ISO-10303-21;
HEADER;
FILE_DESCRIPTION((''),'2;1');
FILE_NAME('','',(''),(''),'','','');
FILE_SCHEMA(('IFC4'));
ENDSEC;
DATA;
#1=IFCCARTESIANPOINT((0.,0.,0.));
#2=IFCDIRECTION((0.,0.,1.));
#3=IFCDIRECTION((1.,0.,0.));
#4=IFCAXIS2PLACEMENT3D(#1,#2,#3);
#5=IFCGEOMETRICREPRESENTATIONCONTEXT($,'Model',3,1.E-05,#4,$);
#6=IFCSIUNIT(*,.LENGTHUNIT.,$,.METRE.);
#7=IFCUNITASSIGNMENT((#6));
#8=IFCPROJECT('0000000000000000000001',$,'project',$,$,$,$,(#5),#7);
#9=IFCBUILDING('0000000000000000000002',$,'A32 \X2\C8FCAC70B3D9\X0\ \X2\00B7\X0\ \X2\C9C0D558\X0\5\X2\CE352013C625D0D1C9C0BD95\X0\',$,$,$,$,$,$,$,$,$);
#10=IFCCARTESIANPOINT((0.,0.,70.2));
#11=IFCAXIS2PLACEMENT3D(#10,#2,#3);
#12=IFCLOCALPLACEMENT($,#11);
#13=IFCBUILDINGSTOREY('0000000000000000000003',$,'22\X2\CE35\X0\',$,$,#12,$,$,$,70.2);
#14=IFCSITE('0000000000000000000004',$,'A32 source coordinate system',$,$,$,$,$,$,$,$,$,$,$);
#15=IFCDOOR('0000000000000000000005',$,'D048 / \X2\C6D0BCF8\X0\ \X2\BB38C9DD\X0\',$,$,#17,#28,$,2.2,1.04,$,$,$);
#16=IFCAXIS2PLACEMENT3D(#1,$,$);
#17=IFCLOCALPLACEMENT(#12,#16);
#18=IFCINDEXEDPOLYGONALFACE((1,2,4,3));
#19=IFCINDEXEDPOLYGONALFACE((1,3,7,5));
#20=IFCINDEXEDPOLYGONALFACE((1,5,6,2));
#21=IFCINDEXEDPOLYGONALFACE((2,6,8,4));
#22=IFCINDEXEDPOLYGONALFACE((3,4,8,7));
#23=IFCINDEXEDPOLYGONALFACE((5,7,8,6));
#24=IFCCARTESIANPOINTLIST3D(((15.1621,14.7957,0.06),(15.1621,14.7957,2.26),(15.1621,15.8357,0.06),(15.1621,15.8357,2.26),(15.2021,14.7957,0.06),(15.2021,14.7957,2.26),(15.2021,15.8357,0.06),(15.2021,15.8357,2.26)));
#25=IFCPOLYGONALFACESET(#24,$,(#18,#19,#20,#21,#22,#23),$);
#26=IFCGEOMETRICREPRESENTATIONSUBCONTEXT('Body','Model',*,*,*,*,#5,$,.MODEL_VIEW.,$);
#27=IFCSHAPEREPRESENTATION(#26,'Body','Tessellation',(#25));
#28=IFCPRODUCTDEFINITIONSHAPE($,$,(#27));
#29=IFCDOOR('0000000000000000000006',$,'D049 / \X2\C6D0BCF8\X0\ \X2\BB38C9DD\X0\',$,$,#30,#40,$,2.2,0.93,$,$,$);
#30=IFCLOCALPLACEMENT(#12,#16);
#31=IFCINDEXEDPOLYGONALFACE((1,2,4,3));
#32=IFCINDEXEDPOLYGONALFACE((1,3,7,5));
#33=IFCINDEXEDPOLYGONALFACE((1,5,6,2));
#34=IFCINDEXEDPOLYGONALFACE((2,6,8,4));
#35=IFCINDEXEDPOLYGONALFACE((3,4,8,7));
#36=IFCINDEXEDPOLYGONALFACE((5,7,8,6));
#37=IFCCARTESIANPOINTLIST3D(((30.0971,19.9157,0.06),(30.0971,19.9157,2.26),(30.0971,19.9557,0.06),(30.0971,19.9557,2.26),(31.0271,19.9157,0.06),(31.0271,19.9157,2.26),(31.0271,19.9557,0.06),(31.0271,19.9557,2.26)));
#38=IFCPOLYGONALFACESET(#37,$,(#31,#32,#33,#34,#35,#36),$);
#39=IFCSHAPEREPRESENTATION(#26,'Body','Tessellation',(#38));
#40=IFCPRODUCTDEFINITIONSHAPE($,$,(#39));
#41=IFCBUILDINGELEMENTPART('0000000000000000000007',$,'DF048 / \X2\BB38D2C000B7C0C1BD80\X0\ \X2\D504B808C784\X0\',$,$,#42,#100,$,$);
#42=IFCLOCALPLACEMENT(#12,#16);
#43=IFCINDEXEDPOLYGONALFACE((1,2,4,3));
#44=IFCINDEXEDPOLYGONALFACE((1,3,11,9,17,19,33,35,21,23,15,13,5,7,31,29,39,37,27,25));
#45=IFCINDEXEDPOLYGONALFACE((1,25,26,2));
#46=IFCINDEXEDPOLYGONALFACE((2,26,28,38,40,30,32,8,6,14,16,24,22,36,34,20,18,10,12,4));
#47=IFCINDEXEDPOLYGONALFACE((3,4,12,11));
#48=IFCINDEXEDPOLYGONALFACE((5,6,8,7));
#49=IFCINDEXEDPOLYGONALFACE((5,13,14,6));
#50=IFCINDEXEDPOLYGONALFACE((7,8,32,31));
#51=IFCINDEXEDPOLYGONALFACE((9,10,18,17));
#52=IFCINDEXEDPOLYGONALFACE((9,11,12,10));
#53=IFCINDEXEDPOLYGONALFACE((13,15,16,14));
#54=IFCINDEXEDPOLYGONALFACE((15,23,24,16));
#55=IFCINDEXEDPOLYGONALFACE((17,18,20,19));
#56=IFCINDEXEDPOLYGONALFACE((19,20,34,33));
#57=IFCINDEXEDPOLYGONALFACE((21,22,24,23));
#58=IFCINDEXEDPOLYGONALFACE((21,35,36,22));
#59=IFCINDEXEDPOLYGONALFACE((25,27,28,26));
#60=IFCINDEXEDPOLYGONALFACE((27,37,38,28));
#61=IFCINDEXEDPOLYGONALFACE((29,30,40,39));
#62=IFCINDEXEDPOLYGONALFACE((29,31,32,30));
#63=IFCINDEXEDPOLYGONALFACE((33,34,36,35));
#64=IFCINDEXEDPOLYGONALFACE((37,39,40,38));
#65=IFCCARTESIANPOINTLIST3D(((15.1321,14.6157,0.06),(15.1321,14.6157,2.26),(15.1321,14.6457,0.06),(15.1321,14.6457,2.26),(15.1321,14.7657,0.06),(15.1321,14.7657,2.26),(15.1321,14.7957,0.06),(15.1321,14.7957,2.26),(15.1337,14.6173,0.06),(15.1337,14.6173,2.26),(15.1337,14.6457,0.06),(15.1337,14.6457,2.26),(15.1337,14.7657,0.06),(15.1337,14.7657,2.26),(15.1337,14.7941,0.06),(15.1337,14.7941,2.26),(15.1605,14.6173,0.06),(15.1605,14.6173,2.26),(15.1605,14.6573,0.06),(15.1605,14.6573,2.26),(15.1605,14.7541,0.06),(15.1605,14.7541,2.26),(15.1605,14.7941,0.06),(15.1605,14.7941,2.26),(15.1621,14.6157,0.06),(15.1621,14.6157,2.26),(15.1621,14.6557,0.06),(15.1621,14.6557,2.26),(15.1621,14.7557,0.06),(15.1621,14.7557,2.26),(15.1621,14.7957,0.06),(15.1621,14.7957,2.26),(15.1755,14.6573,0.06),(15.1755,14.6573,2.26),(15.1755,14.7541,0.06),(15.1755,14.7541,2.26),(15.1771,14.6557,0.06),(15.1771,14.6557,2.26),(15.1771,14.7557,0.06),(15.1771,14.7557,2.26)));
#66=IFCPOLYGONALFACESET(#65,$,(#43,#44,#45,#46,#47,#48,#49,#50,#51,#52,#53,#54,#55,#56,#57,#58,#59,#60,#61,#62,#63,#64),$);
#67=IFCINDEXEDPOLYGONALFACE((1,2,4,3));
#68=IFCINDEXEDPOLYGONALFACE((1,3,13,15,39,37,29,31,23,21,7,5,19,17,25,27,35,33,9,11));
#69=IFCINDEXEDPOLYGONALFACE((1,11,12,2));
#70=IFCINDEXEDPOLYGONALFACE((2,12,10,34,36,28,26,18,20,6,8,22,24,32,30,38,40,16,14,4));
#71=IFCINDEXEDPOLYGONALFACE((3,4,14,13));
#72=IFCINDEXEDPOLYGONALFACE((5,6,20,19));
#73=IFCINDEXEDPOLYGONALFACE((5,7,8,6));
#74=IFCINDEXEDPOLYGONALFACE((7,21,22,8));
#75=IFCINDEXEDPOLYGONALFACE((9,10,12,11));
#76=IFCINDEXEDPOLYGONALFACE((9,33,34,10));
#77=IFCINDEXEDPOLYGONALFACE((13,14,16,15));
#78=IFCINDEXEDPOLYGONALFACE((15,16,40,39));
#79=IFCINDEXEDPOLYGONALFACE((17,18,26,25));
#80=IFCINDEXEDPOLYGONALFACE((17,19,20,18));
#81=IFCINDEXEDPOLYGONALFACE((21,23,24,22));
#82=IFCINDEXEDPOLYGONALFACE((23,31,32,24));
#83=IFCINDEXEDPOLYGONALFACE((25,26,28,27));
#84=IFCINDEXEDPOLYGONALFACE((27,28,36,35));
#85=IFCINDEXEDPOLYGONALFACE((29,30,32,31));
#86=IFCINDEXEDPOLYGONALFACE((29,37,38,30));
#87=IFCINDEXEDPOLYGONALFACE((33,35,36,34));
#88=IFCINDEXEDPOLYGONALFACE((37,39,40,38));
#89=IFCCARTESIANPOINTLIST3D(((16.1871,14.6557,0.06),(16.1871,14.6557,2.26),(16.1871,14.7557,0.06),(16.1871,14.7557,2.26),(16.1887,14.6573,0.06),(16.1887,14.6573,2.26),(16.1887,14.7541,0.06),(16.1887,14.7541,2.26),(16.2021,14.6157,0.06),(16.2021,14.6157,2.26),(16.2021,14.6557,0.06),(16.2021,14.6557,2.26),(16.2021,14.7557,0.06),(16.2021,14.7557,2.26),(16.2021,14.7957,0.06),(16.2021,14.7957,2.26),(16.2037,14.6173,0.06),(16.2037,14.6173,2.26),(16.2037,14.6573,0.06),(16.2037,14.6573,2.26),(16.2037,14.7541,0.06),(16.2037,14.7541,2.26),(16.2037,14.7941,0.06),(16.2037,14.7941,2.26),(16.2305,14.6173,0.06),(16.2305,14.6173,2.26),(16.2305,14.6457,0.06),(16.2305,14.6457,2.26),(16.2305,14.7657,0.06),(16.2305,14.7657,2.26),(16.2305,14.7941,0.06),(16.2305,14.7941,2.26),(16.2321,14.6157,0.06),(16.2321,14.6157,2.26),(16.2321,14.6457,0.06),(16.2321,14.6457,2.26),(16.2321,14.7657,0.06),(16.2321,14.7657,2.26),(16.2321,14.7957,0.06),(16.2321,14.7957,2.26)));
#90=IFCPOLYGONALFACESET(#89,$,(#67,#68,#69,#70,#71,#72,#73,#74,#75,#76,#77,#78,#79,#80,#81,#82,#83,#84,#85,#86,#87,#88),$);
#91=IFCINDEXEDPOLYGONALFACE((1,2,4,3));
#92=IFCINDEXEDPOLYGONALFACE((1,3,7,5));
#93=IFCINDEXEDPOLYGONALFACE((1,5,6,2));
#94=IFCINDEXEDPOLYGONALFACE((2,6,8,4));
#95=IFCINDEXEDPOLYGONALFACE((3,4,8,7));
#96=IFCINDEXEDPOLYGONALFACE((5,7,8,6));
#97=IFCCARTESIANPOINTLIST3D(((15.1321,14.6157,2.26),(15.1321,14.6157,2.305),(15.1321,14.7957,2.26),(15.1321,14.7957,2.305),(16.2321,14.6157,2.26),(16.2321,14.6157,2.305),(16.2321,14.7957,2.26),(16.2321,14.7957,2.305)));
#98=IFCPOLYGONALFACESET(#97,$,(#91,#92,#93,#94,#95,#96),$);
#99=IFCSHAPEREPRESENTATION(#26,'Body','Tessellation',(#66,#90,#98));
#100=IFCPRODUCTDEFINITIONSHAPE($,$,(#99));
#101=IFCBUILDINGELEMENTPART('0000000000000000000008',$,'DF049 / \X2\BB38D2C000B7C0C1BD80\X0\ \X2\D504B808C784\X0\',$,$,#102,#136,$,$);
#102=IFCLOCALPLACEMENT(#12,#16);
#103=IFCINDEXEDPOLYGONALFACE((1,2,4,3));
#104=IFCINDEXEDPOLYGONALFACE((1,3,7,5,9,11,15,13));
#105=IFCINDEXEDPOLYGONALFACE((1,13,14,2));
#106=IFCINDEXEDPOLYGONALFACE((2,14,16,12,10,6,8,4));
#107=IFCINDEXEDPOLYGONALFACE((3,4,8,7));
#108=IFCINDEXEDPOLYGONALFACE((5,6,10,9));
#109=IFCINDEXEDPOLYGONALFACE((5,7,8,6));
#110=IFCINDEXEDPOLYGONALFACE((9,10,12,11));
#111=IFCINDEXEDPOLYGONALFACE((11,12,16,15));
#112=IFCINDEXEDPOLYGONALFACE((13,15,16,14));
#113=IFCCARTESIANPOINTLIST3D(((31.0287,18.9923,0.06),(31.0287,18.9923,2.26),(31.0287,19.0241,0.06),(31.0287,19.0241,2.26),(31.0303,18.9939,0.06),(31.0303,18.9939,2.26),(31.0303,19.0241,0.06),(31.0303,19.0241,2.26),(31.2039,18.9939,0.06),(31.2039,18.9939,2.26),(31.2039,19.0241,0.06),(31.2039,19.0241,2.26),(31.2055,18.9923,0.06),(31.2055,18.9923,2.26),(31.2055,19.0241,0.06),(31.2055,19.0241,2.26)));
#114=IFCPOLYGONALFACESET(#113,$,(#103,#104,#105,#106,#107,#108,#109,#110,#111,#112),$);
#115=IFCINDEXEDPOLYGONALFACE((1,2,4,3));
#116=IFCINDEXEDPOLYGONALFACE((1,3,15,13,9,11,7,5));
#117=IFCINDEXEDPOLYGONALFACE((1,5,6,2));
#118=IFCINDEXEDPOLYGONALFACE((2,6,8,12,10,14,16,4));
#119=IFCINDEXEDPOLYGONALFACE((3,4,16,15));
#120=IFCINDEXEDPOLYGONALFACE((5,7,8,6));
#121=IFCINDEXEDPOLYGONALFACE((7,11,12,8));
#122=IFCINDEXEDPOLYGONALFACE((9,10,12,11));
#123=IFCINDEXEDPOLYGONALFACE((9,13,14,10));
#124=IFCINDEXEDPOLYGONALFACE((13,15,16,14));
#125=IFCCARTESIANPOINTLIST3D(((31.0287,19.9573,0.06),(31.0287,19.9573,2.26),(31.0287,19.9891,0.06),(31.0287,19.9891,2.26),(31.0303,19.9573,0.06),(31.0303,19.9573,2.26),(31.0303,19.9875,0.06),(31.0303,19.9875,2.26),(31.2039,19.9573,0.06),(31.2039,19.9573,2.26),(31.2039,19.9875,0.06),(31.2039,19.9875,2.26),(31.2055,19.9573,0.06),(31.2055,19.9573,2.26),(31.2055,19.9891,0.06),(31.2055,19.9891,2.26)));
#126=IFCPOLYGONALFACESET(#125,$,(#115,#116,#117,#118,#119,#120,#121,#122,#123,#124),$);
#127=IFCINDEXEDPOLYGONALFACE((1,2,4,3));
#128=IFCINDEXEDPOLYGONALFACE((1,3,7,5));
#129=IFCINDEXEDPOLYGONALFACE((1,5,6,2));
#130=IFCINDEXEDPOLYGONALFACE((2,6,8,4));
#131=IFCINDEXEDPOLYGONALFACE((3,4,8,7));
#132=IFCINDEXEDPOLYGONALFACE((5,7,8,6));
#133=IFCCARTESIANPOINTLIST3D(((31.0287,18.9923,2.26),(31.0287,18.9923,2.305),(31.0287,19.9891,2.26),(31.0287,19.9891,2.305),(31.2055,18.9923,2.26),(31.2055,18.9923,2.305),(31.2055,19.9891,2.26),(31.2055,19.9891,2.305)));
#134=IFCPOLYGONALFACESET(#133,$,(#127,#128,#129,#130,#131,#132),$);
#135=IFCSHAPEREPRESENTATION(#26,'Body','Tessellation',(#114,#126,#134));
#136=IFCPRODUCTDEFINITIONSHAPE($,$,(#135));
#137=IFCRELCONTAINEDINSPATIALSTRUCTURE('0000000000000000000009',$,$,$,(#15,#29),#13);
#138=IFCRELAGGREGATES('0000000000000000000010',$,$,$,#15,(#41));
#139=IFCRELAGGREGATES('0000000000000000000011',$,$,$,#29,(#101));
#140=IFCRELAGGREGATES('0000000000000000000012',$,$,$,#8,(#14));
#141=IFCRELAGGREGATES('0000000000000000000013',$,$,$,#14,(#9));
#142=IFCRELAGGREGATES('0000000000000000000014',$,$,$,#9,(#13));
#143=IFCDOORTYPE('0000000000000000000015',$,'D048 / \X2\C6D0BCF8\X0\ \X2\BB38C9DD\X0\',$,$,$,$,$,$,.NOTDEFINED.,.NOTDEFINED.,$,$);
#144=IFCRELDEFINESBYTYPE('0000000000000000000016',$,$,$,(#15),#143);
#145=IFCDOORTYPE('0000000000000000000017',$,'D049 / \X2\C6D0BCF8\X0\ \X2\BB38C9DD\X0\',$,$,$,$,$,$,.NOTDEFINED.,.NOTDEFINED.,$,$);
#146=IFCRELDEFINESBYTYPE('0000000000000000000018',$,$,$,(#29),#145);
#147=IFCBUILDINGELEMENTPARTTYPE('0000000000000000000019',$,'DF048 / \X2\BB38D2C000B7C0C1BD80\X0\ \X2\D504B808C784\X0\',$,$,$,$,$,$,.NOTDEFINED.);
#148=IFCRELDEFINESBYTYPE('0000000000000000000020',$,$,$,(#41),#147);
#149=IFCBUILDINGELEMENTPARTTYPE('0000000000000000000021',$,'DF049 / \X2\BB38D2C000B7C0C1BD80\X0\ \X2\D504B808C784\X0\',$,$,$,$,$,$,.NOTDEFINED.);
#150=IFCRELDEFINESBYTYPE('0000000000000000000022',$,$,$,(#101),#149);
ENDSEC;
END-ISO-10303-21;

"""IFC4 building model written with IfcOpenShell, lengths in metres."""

from ifc_helpers import new_model, si_unit, frame, origin, origin_with_axes, place, context, subcontext, project, spatial, polyline, outline, extrude, source, transform, mapped, type_object, type_shapes, element, aggregate, save


model = new_model("IFC4")

# Units and contexts
model_context = context("Model", 3, precision=1e-05, world=origin_with_axes())
body_context = subcontext(model_context, "Body", "Model", "MODEL_VIEW")
ifc_project = project(units=[si_unit("LENGTHUNIT", "METRE")], contexts=[model_context])

# Site, building, storey
storey_placement = place(None, frame((0.0, 0.0, 70.2), z_axis=(0.0, 0.0, 1.0), x_axis=(1.0, 0.0, 0.0)))
site = spatial("IfcSite", under=ifc_project, Name="A32 source coordinate system")
building = spatial("IfcBuilding", under=site, Name="A32 주거동 · 지하5층–옥탑지붕")
storey = spatial("IfcBuildingStorey", under=building, at=storey_placement, Name="22층", Elevation=70.2)

# Doors
door_type_1 = type_object("IfcDoorType", Name="D048 / 원본 문짝", OperationType="NOTDEFINED", PredefinedType="NOTDEFINED")
shared_shape_1 = source(origin(), body_context, "Body", "SweptSolid", [
    extrude(outline(polyline([(15.2021, 15.8357), (15.2021, 14.7957), (15.1621, 14.7957), (15.1621, 15.8357), (15.2021, 15.8357)])), frame((0.0, 0.0, 0.06)), (0.0, 0.0, 1.0), 2.2),
])
type_shapes(door_type_1, [shared_shape_1])
door_1_placement = place(storey_placement, origin_with_axes())
door_1 = element("IfcDoor", 1, at=door_1_placement, inside=storey, type_object=door_type_1, Name="D048 / 원본 문짝", OverallHeight=2.2, OverallWidth=1.04, context=body_context, shape_type="MappedRepresentation", body=[
    mapped(shared_shape_1, transform((0.0, 0.0, 0.0), scale=1.0)),
])
door_type_2 = type_object("IfcDoorType", Name="D049 / 원본 문짝", OperationType="NOTDEFINED", PredefinedType="NOTDEFINED")
shared_shape_2 = source(origin(), body_context, "Body", "SweptSolid", [
    extrude(outline(polyline([(31.0271, 19.9557), (31.0271, 19.9157), (30.0971, 19.9157), (30.0971, 19.9557), (31.0271, 19.9557)])), frame((0.0, 0.0, 0.06)), (0.0, 0.0, 1.0), 2.2),
])
type_shapes(door_type_2, [shared_shape_2])
door_2_placement = place(storey_placement, origin_with_axes())
door_2 = element("IfcDoor", 2, at=door_2_placement, inside=storey, type_object=door_type_2, Name="D049 / 원본 문짝", OverallHeight=2.2, OverallWidth=0.93, context=body_context, shape_type="MappedRepresentation", body=[
    mapped(shared_shape_2, transform((0.0, 0.0, 0.0), scale=1.0)),
])

# Building element parts
building_element_part_type_1 = type_object("IfcBuildingElementPartType", Name="DF048 / 문틀·상부 프레임", PredefinedType="NOTDEFINED")
shared_shape_3 = source(origin(), body_context, "Body", "SweptSolid", [
    extrude(outline(polyline([(15.1321, 14.7657), (15.1321, 14.7957), (15.1621, 14.7957), (15.1621, 14.7557), (15.1771, 14.7557), (15.1771, 14.6557), (15.1621, 14.6557), (15.1621, 14.6157), (15.1321, 14.6157), (15.1321, 14.6457), (15.1337, 14.6457), (15.1337, 14.6173), (15.1605, 14.6173), (15.1605, 14.6573), (15.1755, 14.6573), (15.1755, 14.7541), (15.1605, 14.7541), (15.1605, 14.7941), (15.1337, 14.7941), (15.1337, 14.7657), (15.1321, 14.7657)])), frame((0.0, 0.0, 0.06)), (0.0, 0.0, 1.0), 2.2),
    extrude(outline(polyline([(16.2305, 14.7941), (16.2037, 14.7941), (16.2037, 14.7541), (16.1887, 14.7541), (16.1887, 14.6573), (16.2037, 14.6573), (16.2037, 14.6173), (16.2305, 14.6173), (16.2305, 14.6457), (16.2321, 14.6457), (16.2321, 14.6157), (16.2021, 14.6157), (16.2021, 14.6557), (16.1871, 14.6557), (16.1871, 14.7557), (16.2021, 14.7557), (16.2021, 14.7957), (16.2321, 14.7957), (16.2321, 14.7657), (16.2305, 14.7657), (16.2305, 14.7941)])), frame((0.0, 0.0, 0.06)), (0.0, 0.0, 1.0), 2.2),
    extrude(outline(polyline([(15.1321, 14.6157), (15.1321, 14.7957), (16.2321, 14.7957), (16.2321, 14.6157), (15.1321, 14.6157)])), frame((0.0, 0.0, 2.26)), (0.0, 0.0, 1.0), 0.045),
])
type_shapes(building_element_part_type_1, [shared_shape_3])
building_element_part_1_placement = place(door_1_placement, origin_with_axes())
building_element_part_1 = element("IfcBuildingElementPart", 3, at=building_element_part_1_placement, type_object=building_element_part_type_1, Name="DF048 / 문틀·상부 프레임", context=body_context, shape_type="MappedRepresentation", body=[
    mapped(shared_shape_3, transform((0.0, 0.0, 0.0), scale=1.0)),
])
aggregate(door_1, [building_element_part_1])
building_element_part_type_2 = type_object("IfcBuildingElementPartType", Name="DF049 / 문틀·상부 프레임", PredefinedType="NOTDEFINED")
shared_shape_4 = source(origin(), body_context, "Body", "SweptSolid", [
    extrude(outline(polyline([(31.0303, 19.0241), (31.0303, 18.9939), (31.2039, 18.9939), (31.2039, 19.0241), (31.2055, 19.0241), (31.2055, 18.9923), (31.0287, 18.9923), (31.0287, 19.0241), (31.0303, 19.0241)])), frame((0.0, 0.0, 0.06)), (0.0, 0.0, 1.0), 2.2),
    extrude(outline(polyline([(31.0287, 19.9891), (31.2055, 19.9891), (31.2055, 19.9573), (31.2039, 19.9573), (31.2039, 19.9875), (31.0303, 19.9875), (31.0303, 19.9573), (31.0287, 19.9573), (31.0287, 19.9891)])), frame((0.0, 0.0, 0.06)), (0.0, 0.0, 1.0), 2.2),
    extrude(outline(polyline([(31.0287, 18.9923), (31.0287, 19.9891), (31.2055, 19.9891), (31.2055, 18.9923), (31.0287, 18.9923)])), frame((0.0, 0.0, 2.26)), (0.0, 0.0, 1.0), 0.045),
])
type_shapes(building_element_part_type_2, [shared_shape_4])
building_element_part_2_placement = place(door_2_placement, origin_with_axes())
building_element_part_2 = element("IfcBuildingElementPart", 4, at=building_element_part_2_placement, type_object=building_element_part_type_2, Name="DF049 / 문틀·상부 프레임", context=body_context, shape_type="MappedRepresentation", body=[
    mapped(shared_shape_4, transform((0.0, 0.0, 0.0), scale=1.0)),
])
aggregate(door_2, [building_element_part_2])

save(model, "model.ifc")
